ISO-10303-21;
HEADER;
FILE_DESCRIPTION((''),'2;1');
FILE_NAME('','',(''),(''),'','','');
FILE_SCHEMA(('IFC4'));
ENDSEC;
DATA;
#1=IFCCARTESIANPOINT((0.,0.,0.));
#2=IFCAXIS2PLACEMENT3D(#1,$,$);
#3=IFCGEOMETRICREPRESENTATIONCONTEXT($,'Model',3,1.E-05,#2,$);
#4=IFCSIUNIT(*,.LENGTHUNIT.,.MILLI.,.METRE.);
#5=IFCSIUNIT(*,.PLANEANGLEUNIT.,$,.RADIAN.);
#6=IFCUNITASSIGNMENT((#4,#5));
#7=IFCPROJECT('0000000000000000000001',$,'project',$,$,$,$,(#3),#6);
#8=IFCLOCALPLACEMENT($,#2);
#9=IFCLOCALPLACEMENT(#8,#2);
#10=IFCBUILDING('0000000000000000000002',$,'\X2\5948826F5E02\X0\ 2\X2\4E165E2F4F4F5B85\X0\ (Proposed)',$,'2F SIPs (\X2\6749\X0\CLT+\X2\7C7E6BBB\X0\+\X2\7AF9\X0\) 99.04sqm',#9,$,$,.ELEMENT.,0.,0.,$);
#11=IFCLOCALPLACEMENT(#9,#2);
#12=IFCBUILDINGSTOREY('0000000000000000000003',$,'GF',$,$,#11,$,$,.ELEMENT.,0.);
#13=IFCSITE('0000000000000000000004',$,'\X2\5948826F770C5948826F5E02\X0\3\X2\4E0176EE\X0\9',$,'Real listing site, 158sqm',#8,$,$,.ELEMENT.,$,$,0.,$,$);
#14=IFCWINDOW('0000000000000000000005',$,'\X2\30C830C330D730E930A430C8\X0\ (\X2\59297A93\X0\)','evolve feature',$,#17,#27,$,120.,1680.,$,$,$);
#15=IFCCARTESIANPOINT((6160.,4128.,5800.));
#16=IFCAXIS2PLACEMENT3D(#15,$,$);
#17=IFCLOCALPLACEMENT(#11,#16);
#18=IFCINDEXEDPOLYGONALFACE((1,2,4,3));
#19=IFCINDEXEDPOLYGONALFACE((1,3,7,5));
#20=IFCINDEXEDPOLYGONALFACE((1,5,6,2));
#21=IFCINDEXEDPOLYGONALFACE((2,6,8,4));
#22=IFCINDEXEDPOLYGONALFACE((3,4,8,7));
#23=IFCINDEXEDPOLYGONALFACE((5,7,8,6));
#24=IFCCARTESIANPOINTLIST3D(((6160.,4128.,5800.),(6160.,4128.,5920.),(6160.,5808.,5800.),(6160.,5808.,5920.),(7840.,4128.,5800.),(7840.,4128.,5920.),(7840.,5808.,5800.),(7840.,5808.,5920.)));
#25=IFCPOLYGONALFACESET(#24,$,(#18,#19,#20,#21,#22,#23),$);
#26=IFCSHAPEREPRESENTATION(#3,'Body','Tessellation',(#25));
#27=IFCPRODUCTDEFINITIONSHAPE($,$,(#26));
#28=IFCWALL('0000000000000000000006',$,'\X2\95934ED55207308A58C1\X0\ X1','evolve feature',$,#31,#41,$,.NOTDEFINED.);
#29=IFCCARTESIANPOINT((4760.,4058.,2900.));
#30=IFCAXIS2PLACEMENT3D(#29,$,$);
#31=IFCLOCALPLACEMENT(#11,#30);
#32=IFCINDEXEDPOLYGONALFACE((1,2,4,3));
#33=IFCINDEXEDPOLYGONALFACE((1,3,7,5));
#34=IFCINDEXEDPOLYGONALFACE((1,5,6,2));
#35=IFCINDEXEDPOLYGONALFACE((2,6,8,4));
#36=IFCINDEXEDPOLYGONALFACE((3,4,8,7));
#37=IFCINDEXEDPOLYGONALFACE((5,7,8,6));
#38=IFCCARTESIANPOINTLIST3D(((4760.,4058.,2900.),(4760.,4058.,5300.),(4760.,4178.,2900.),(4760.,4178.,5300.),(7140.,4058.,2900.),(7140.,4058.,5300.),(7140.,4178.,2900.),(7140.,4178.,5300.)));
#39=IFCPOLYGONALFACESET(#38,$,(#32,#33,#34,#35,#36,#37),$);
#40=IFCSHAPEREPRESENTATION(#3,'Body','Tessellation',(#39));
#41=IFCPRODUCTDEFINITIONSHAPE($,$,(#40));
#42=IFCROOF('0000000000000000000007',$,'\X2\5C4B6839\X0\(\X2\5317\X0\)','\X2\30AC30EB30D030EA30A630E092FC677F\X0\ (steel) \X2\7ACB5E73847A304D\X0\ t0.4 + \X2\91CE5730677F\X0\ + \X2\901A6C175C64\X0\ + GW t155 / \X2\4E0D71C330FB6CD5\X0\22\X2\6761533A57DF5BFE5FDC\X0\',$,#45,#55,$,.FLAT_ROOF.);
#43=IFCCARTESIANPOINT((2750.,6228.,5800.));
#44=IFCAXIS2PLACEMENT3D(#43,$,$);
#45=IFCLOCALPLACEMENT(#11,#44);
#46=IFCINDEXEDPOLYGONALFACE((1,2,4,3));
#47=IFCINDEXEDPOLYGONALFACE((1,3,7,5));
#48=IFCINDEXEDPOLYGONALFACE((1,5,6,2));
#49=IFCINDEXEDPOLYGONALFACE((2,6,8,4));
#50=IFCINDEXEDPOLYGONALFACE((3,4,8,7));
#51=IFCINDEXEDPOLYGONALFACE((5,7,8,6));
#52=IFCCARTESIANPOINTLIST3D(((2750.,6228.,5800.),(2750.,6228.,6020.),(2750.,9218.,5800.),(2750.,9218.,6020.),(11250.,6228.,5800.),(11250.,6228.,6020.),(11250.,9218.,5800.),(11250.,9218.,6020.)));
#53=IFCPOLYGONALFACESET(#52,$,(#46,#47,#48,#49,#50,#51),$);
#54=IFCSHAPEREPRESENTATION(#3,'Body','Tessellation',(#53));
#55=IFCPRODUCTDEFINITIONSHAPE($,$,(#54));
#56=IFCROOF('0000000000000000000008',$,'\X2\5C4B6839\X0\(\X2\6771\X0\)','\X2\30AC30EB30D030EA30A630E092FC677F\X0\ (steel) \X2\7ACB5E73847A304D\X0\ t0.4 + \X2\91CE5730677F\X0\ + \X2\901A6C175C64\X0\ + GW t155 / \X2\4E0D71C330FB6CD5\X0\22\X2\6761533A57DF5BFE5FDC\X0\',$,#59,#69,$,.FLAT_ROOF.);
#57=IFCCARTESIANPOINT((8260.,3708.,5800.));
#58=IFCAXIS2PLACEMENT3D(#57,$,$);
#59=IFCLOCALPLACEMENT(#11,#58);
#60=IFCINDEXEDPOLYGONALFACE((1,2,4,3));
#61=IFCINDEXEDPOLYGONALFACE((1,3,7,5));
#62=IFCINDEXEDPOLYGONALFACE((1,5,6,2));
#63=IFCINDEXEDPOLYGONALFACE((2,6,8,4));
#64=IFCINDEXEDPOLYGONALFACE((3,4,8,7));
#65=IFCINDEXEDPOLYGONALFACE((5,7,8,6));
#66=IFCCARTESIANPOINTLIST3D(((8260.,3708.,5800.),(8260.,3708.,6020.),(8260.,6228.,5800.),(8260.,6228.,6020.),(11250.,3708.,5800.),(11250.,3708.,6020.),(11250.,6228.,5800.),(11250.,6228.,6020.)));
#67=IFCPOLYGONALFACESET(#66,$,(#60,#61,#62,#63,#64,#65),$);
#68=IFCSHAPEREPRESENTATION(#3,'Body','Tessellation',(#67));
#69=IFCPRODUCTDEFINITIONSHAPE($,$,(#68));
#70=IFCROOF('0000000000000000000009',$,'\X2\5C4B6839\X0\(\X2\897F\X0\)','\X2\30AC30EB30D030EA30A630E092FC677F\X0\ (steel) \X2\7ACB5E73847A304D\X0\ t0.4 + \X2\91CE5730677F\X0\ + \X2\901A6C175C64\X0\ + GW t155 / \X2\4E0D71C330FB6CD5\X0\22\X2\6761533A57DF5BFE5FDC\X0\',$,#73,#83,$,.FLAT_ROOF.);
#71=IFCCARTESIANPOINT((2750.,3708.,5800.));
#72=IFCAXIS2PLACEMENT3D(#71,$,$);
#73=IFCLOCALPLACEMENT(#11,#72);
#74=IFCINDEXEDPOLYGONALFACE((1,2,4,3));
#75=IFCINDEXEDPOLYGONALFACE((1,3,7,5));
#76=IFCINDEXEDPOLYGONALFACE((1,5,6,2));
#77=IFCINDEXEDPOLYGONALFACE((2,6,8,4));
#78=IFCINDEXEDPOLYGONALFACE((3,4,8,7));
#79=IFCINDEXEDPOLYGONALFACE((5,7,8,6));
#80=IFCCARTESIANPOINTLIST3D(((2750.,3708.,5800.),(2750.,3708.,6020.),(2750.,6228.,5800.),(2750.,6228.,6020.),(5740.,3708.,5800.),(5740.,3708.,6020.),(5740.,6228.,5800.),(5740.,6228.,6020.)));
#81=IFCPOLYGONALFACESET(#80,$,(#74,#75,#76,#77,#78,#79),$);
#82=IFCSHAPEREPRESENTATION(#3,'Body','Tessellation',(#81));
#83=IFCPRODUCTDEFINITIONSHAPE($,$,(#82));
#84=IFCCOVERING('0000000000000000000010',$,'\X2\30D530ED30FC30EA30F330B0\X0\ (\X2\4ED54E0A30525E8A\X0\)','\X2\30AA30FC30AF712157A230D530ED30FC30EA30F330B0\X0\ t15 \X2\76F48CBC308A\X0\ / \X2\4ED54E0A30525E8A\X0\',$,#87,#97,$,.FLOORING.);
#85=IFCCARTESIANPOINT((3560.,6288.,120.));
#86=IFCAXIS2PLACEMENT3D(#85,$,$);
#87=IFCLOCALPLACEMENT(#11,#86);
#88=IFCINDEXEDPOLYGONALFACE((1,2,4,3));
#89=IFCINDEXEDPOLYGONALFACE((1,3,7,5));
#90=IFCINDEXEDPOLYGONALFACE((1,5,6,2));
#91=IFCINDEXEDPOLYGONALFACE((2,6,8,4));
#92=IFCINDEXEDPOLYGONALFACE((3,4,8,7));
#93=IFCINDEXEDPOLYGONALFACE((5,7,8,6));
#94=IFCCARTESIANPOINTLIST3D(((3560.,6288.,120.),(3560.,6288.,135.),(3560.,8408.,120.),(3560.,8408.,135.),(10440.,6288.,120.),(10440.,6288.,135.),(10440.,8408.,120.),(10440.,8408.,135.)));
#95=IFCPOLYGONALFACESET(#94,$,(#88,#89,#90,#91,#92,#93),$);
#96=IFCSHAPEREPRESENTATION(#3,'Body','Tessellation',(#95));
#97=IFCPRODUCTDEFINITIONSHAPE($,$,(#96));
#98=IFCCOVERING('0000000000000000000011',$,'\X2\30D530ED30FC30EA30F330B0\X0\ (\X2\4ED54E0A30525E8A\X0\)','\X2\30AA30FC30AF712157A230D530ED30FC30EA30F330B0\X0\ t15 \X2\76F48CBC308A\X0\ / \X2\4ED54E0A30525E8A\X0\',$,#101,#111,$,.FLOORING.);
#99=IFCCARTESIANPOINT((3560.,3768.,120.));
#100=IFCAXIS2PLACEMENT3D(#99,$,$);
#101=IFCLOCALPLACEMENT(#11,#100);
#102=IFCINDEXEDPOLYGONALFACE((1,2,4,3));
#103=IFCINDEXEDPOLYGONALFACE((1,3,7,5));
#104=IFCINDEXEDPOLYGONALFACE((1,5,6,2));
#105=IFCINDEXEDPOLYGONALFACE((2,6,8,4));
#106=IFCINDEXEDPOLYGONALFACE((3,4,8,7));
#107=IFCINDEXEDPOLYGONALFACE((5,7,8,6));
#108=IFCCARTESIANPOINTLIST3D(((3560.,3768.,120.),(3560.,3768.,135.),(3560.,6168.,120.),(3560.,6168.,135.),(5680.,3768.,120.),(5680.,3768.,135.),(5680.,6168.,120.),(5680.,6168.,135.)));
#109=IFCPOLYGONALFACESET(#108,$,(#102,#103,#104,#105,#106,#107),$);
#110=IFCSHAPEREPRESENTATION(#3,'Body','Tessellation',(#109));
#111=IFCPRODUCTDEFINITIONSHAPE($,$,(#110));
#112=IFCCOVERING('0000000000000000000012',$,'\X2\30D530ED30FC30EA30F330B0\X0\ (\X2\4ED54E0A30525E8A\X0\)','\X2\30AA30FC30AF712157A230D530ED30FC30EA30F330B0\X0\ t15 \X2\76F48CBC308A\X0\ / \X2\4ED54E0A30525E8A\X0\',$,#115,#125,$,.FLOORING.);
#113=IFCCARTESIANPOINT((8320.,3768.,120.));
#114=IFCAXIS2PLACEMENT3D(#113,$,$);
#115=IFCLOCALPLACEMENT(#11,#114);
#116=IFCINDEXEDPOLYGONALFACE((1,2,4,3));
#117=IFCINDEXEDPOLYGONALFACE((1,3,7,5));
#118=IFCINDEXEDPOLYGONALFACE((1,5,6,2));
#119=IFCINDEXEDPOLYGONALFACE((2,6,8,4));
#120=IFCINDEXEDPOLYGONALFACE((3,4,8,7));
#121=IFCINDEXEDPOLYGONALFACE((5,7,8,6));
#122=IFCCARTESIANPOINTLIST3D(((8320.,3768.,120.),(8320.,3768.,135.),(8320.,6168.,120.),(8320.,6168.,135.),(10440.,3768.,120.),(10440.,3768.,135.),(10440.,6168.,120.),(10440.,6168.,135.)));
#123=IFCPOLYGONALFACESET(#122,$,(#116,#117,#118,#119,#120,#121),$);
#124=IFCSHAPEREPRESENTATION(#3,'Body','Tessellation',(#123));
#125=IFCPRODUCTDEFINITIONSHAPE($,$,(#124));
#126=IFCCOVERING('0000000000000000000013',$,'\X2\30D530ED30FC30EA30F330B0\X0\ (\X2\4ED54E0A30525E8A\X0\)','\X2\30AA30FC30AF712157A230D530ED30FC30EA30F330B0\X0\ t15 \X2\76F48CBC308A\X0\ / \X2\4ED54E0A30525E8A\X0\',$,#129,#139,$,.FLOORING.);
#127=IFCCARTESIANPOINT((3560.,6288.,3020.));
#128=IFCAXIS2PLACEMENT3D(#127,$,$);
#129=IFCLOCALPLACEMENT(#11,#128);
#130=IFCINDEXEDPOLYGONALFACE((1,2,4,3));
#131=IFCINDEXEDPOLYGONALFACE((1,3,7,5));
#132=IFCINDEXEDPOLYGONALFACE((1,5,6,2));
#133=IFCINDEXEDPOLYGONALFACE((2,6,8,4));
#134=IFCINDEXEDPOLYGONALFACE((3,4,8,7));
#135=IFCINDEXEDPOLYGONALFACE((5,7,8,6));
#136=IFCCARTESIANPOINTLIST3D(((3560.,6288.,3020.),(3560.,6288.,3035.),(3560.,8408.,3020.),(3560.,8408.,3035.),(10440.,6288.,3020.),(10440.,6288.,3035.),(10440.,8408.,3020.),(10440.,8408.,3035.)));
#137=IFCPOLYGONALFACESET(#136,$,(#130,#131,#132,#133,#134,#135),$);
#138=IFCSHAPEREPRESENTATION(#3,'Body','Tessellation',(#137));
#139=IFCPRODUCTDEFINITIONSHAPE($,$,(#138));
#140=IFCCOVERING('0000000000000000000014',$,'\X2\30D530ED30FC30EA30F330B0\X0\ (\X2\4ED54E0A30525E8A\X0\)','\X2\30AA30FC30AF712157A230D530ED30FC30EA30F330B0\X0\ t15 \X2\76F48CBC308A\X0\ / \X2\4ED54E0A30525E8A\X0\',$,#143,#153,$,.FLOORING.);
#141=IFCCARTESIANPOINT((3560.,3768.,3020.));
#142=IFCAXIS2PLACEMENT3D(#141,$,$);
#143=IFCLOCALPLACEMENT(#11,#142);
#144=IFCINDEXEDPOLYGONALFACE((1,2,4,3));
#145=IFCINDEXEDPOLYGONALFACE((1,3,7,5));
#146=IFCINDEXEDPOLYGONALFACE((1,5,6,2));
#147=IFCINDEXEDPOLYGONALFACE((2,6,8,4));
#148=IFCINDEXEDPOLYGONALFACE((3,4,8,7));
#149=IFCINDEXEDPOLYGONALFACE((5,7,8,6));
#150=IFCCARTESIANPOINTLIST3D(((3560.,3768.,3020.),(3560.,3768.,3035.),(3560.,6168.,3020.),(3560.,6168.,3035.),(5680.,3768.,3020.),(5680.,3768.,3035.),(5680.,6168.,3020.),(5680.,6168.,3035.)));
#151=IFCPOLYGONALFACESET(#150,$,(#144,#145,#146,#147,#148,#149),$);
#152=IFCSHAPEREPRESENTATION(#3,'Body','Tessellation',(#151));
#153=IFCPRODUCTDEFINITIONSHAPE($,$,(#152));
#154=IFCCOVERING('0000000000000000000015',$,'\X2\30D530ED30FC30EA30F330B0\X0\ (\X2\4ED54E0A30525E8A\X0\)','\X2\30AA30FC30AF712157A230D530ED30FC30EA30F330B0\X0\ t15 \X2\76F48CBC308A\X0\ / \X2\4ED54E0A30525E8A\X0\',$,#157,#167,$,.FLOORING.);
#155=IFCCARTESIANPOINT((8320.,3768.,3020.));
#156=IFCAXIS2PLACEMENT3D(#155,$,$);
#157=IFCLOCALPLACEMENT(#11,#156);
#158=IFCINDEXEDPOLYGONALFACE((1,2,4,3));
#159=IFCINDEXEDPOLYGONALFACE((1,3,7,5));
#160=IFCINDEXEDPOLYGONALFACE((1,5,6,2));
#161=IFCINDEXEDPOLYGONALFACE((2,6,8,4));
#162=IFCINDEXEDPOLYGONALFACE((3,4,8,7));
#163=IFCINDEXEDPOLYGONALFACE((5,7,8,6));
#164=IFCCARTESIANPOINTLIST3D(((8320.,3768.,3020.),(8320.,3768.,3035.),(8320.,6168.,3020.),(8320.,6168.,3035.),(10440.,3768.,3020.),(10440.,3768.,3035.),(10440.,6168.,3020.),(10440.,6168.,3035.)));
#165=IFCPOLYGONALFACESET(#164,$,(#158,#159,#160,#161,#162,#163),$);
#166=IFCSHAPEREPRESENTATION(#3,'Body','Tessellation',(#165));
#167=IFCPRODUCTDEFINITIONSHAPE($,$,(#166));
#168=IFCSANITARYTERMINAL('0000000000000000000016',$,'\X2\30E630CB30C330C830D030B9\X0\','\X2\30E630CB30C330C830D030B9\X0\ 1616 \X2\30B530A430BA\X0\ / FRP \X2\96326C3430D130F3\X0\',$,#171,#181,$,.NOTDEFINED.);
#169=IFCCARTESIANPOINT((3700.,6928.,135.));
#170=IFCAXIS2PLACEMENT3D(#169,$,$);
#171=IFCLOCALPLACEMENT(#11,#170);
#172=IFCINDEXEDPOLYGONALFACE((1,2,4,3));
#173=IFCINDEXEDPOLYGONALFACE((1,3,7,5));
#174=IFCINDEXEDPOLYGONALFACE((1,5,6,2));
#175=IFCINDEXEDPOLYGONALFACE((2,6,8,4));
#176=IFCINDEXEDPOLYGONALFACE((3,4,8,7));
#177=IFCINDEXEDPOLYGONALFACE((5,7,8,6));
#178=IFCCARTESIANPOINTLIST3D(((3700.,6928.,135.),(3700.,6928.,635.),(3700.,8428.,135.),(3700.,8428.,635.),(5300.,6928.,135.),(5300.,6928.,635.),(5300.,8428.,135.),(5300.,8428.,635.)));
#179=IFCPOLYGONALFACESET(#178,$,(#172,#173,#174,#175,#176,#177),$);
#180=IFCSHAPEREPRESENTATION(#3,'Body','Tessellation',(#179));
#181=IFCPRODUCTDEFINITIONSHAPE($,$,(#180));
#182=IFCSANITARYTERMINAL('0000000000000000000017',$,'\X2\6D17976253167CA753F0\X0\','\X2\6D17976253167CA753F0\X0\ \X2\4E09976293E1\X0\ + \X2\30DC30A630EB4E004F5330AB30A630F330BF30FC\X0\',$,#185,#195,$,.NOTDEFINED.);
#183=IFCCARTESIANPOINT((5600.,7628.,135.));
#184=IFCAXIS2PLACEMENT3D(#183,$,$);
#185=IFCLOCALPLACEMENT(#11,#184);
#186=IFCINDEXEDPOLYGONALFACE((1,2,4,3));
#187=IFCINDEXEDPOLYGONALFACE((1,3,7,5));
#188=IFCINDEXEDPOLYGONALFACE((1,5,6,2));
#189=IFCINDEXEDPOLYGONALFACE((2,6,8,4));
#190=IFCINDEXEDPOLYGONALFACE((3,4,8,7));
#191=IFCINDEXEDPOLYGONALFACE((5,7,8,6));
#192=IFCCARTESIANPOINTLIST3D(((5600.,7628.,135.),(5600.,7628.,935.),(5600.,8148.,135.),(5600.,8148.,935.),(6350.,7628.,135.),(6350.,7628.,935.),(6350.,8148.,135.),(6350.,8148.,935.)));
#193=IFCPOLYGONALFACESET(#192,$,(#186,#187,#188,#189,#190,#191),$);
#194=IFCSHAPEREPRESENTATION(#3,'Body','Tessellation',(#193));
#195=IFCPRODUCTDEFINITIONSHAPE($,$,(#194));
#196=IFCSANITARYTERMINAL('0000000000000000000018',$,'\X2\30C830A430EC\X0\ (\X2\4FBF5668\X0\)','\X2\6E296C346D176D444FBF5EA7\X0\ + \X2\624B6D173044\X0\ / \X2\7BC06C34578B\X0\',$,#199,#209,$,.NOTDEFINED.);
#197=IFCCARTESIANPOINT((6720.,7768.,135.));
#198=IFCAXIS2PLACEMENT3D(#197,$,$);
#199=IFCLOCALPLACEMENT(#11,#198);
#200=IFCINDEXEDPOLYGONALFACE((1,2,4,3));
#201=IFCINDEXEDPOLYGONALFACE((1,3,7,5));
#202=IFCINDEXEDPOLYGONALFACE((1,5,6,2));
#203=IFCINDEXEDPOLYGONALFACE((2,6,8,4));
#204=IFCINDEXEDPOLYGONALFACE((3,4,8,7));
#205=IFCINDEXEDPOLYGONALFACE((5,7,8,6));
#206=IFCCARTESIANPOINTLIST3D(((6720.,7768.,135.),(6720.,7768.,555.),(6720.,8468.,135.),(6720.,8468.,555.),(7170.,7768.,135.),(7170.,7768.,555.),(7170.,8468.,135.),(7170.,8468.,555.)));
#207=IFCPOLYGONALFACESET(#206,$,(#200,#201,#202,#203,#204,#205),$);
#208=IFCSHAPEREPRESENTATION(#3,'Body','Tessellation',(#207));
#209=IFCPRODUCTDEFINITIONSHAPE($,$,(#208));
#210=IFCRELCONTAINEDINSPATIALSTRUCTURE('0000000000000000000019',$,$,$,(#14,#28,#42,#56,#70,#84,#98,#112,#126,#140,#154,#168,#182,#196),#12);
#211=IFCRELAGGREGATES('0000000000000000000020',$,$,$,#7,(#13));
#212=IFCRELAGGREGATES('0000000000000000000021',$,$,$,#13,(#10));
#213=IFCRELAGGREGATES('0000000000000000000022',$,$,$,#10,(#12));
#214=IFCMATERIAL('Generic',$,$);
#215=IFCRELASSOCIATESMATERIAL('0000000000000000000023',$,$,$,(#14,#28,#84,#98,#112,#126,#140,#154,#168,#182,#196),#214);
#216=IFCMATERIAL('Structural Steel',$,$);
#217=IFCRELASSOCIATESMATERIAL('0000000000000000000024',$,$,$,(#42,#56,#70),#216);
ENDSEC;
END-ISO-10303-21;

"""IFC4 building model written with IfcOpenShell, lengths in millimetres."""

from ifc_helpers import new_model, si_unit, frame, frame_2d, origin, place, context, project, spatial, rectangle, extrude, material, element, save


model = new_model("IFC4")

# Units and contexts
model_context = context("Model", 3, precision=1e-05, world=origin())
ifc_project = project(units=[si_unit("LENGTHUNIT", "METRE", prefix="MILLI"), si_unit("PLANEANGLEUNIT", "RADIAN")], contexts=[model_context])

# Site, building, storey
site_placement = place(None, origin())
site = spatial("IfcSite", under=ifc_project, at=site_placement, Name="奈良県奈良市3丁目9", ObjectType="Real listing site, 158sqm", CompositionType="ELEMENT", RefElevation=0.0)
building_placement = place(site_placement, origin())
building = spatial("IfcBuilding", under=site, at=building_placement, Name="奈良市 2世帯住宅 (Proposed)", ObjectType="2F SIPs (杉CLT+籾殻+竹) 99.04sqm", CompositionType="ELEMENT", ElevationOfRefHeight=0.0, ElevationOfTerrain=0.0)
storey_placement = place(building_placement, origin())
storey = spatial("IfcBuildingStorey", under=building, at=storey_placement, Name="GF", CompositionType="ELEMENT", Elevation=0.0)

# Window
ifc_material_1 = material(Name="Generic")
window_1_placement = place(storey_placement, frame((6160.0, 4128.0, 5800.0)))
element("IfcWindow", 1, at=window_1_placement, inside=storey, material=ifc_material_1, Name="トップライト (天窓)", Description="evolve feature", OverallHeight=120.0, OverallWidth=1680.0, context=model_context, shape_type="SweptSolid", body=[
    extrude(rectangle(XDim=1680.0, YDim=1680.0, at=frame_2d((840.0, 840.0))), frame((6160.0, 4128.0, 5800.0)), (0.0, 0.0, 1.0), 120.0),
])

# Wall
wall_1_placement = place(storey_placement, frame((4760.0, 4058.0, 2900.0)))
element("IfcWall", 2, at=wall_1_placement, inside=storey, material=ifc_material_1, Name="間仕切り壁 X1", Description="evolve feature", PredefinedType="NOTDEFINED", context=model_context, shape_type="SweptSolid", body=[
    extrude(rectangle(XDim=2380.0, YDim=120.0, at=frame_2d((1190.0, 60.0))), frame((4760.0, 4058.0, 2900.0)), (0.0, 0.0, 1.0), 2400.0),
])

# Roofs
ifc_material_2 = material(Name="Structural Steel")
roof_1_placement = place(storey_placement, frame((2750.0, 6228.0, 5800.0)))
element("IfcRoof", 3, at=roof_1_placement, inside=storey, material=ifc_material_2, Name="屋根(北)", Description="ガルバリウム鋼板 (steel) 立平葺き t0.4 + 野地板 + 通気層 + GW t155 / 不燃・法22条区域対応", PredefinedType="FLAT_ROOF", context=model_context, shape_type="SweptSolid", body=[
    extrude(rectangle(XDim=8500.0, YDim=2990.0, at=frame_2d((4250.0, 1495.0))), frame((2750.0, 6228.0, 5800.0)), (0.0, 0.0, 1.0), 220.0),
])
roof_2_placement = place(storey_placement, frame((8260.0, 3708.0, 5800.0)))
element("IfcRoof", 4, at=roof_2_placement, inside=storey, material=ifc_material_2, Name="屋根(東)", Description="ガルバリウム鋼板 (steel) 立平葺き t0.4 + 野地板 + 通気層 + GW t155 / 不燃・法22条区域対応", PredefinedType="FLAT_ROOF", context=model_context, shape_type="SweptSolid", body=[
    extrude(rectangle(XDim=2990.0, YDim=2520.0, at=frame_2d((1495.0, 1260.0))), frame((8260.0, 3708.0, 5800.0)), (0.0, 0.0, 1.0), 220.0),
])
roof_3_placement = place(storey_placement, frame((2750.0, 3708.0, 5800.0)))
element("IfcRoof", 5, at=roof_3_placement, inside=storey, material=ifc_material_2, Name="屋根(西)", Description="ガルバリウム鋼板 (steel) 立平葺き t0.4 + 野地板 + 通気層 + GW t155 / 不燃・法22条区域対応", PredefinedType="FLAT_ROOF", context=model_context, shape_type="SweptSolid", body=[
    extrude(rectangle(XDim=2990.0, YDim=2520.0, at=frame_2d((1495.0, 1260.0))), frame((2750.0, 3708.0, 5800.0)), (0.0, 0.0, 1.0), 220.0),
])

# Coverings
covering_1_placement = place(storey_placement, frame((3560.0, 6288.0, 120.0)))
element("IfcCovering", 6, at=covering_1_placement, inside=storey, material=ifc_material_1, Name="フローリング (仕上げ床)", Description="オーク無垢フローリング t15 直貼り / 仕上げ床", PredefinedType="FLOORING", context=model_context, shape_type="SweptSolid", body=[
    extrude(rectangle(XDim=6880.0, YDim=2120.0, at=frame_2d((3440.0, 1060.0))), frame((3560.0, 6288.0, 120.0)), (0.0, 0.0, 1.0), 15.0),
])
covering_2_placement = place(storey_placement, frame((3560.0, 3768.0, 120.0)))
element("IfcCovering", 7, at=covering_2_placement, inside=storey, material=ifc_material_1, Name="フローリング (仕上げ床)", Description="オーク無垢フローリング t15 直貼り / 仕上げ床", PredefinedType="FLOORING", context=model_context, shape_type="SweptSolid", body=[
    extrude(rectangle(XDim=2120.0, YDim=2400.0, at=frame_2d((1060.0, 1200.0))), frame((3560.0, 3768.0, 120.0)), (0.0, 0.0, 1.0), 15.0),
])
covering_3_placement = place(storey_placement, frame((8320.0, 3768.0, 120.0)))
element("IfcCovering", 8, at=covering_3_placement, inside=storey, material=ifc_material_1, Name="フローリング (仕上げ床)", Description="オーク無垢フローリング t15 直貼り / 仕上げ床", PredefinedType="FLOORING", context=model_context, shape_type="SweptSolid", body=[
    extrude(rectangle(XDim=2120.0, YDim=2400.0, at=frame_2d((1060.0, 1200.0))), frame((8320.0, 3768.0, 120.0)), (0.0, 0.0, 1.0), 15.0),
])
covering_4_placement = place(storey_placement, frame((3560.0, 6288.0, 3020.0)))
element("IfcCovering", 9, at=covering_4_placement, inside=storey, material=ifc_material_1, Name="フローリング (仕上げ床)", Description="オーク無垢フローリング t15 直貼り / 仕上げ床", PredefinedType="FLOORING", context=model_context, shape_type="SweptSolid", body=[
    extrude(rectangle(XDim=6880.0, YDim=2120.0, at=frame_2d((3440.0, 1060.0))), frame((3560.0, 6288.0, 3020.0)), (0.0, 0.0, 1.0), 15.0),
])
covering_5_placement = place(storey_placement, frame((3560.0, 3768.0, 3020.0)))
element("IfcCovering", 10, at=covering_5_placement, inside=storey, material=ifc_material_1, Name="フローリング (仕上げ床)", Description="オーク無垢フローリング t15 直貼り / 仕上げ床", PredefinedType="FLOORING", context=model_context, shape_type="SweptSolid", body=[
    extrude(rectangle(XDim=2120.0, YDim=2400.0, at=frame_2d((1060.0, 1200.0))), frame((3560.0, 3768.0, 3020.0)), (0.0, 0.0, 1.0), 15.0),
])
covering_6_placement = place(storey_placement, frame((8320.0, 3768.0, 3020.0)))
element("IfcCovering", 11, at=covering_6_placement, inside=storey, material=ifc_material_1, Name="フローリング (仕上げ床)", Description="オーク無垢フローリング t15 直貼り / 仕上げ床", PredefinedType="FLOORING", context=model_context, shape_type="SweptSolid", body=[
    extrude(rectangle(XDim=2120.0, YDim=2400.0, at=frame_2d((1060.0, 1200.0))), frame((8320.0, 3768.0, 3020.0)), (0.0, 0.0, 1.0), 15.0),
])

# Sanitary terminals
sanitary_terminal_1_placement = place(storey_placement, frame((3700.0, 6928.0, 135.0)))
element("IfcSanitaryTerminal", 12, at=sanitary_terminal_1_placement, inside=storey, material=ifc_material_1, Name="ユニットバス", Description="ユニットバス 1616 サイズ / FRP 防水パン", PredefinedType="NOTDEFINED", context=model_context, shape_type="SweptSolid", body=[
    extrude(rectangle(XDim=1600.0, YDim=1500.0, at=frame_2d((800.0, 750.0))), frame((3700.0, 6928.0, 135.0)), (0.0, 0.0, 1.0), 500.0),
])
sanitary_terminal_2_placement = place(storey_placement, frame((5600.0, 7628.0, 135.0)))
element("IfcSanitaryTerminal", 13, at=sanitary_terminal_2_placement, inside=storey, material=ifc_material_1, Name="洗面化粧台", Description="洗面化粧台 三面鏡 + ボウル一体カウンター", PredefinedType="NOTDEFINED", context=model_context, shape_type="SweptSolid", body=[
    extrude(rectangle(XDim=750.0, YDim=520.0, at=frame_2d((375.0, 260.0))), frame((5600.0, 7628.0, 135.0)), (0.0, 0.0, 1.0), 800.0),
])
sanitary_terminal_3_placement = place(storey_placement, frame((6720.0, 7768.0, 135.0)))
element("IfcSanitaryTerminal", 14, at=sanitary_terminal_3_placement, inside=storey, material=ifc_material_1, Name="トイレ (便器)", Description="温水洗浄便座 + 手洗い / 節水型", PredefinedType="NOTDEFINED", context=model_context, shape_type="SweptSolid", body=[
    extrude(rectangle(XDim=450.0, YDim=700.0, at=frame_2d((225.0, 350.0))), frame((6720.0, 7768.0, 135.0)), (0.0, 0.0, 1.0), 420.0),
])

save(model, "model.ifc")
